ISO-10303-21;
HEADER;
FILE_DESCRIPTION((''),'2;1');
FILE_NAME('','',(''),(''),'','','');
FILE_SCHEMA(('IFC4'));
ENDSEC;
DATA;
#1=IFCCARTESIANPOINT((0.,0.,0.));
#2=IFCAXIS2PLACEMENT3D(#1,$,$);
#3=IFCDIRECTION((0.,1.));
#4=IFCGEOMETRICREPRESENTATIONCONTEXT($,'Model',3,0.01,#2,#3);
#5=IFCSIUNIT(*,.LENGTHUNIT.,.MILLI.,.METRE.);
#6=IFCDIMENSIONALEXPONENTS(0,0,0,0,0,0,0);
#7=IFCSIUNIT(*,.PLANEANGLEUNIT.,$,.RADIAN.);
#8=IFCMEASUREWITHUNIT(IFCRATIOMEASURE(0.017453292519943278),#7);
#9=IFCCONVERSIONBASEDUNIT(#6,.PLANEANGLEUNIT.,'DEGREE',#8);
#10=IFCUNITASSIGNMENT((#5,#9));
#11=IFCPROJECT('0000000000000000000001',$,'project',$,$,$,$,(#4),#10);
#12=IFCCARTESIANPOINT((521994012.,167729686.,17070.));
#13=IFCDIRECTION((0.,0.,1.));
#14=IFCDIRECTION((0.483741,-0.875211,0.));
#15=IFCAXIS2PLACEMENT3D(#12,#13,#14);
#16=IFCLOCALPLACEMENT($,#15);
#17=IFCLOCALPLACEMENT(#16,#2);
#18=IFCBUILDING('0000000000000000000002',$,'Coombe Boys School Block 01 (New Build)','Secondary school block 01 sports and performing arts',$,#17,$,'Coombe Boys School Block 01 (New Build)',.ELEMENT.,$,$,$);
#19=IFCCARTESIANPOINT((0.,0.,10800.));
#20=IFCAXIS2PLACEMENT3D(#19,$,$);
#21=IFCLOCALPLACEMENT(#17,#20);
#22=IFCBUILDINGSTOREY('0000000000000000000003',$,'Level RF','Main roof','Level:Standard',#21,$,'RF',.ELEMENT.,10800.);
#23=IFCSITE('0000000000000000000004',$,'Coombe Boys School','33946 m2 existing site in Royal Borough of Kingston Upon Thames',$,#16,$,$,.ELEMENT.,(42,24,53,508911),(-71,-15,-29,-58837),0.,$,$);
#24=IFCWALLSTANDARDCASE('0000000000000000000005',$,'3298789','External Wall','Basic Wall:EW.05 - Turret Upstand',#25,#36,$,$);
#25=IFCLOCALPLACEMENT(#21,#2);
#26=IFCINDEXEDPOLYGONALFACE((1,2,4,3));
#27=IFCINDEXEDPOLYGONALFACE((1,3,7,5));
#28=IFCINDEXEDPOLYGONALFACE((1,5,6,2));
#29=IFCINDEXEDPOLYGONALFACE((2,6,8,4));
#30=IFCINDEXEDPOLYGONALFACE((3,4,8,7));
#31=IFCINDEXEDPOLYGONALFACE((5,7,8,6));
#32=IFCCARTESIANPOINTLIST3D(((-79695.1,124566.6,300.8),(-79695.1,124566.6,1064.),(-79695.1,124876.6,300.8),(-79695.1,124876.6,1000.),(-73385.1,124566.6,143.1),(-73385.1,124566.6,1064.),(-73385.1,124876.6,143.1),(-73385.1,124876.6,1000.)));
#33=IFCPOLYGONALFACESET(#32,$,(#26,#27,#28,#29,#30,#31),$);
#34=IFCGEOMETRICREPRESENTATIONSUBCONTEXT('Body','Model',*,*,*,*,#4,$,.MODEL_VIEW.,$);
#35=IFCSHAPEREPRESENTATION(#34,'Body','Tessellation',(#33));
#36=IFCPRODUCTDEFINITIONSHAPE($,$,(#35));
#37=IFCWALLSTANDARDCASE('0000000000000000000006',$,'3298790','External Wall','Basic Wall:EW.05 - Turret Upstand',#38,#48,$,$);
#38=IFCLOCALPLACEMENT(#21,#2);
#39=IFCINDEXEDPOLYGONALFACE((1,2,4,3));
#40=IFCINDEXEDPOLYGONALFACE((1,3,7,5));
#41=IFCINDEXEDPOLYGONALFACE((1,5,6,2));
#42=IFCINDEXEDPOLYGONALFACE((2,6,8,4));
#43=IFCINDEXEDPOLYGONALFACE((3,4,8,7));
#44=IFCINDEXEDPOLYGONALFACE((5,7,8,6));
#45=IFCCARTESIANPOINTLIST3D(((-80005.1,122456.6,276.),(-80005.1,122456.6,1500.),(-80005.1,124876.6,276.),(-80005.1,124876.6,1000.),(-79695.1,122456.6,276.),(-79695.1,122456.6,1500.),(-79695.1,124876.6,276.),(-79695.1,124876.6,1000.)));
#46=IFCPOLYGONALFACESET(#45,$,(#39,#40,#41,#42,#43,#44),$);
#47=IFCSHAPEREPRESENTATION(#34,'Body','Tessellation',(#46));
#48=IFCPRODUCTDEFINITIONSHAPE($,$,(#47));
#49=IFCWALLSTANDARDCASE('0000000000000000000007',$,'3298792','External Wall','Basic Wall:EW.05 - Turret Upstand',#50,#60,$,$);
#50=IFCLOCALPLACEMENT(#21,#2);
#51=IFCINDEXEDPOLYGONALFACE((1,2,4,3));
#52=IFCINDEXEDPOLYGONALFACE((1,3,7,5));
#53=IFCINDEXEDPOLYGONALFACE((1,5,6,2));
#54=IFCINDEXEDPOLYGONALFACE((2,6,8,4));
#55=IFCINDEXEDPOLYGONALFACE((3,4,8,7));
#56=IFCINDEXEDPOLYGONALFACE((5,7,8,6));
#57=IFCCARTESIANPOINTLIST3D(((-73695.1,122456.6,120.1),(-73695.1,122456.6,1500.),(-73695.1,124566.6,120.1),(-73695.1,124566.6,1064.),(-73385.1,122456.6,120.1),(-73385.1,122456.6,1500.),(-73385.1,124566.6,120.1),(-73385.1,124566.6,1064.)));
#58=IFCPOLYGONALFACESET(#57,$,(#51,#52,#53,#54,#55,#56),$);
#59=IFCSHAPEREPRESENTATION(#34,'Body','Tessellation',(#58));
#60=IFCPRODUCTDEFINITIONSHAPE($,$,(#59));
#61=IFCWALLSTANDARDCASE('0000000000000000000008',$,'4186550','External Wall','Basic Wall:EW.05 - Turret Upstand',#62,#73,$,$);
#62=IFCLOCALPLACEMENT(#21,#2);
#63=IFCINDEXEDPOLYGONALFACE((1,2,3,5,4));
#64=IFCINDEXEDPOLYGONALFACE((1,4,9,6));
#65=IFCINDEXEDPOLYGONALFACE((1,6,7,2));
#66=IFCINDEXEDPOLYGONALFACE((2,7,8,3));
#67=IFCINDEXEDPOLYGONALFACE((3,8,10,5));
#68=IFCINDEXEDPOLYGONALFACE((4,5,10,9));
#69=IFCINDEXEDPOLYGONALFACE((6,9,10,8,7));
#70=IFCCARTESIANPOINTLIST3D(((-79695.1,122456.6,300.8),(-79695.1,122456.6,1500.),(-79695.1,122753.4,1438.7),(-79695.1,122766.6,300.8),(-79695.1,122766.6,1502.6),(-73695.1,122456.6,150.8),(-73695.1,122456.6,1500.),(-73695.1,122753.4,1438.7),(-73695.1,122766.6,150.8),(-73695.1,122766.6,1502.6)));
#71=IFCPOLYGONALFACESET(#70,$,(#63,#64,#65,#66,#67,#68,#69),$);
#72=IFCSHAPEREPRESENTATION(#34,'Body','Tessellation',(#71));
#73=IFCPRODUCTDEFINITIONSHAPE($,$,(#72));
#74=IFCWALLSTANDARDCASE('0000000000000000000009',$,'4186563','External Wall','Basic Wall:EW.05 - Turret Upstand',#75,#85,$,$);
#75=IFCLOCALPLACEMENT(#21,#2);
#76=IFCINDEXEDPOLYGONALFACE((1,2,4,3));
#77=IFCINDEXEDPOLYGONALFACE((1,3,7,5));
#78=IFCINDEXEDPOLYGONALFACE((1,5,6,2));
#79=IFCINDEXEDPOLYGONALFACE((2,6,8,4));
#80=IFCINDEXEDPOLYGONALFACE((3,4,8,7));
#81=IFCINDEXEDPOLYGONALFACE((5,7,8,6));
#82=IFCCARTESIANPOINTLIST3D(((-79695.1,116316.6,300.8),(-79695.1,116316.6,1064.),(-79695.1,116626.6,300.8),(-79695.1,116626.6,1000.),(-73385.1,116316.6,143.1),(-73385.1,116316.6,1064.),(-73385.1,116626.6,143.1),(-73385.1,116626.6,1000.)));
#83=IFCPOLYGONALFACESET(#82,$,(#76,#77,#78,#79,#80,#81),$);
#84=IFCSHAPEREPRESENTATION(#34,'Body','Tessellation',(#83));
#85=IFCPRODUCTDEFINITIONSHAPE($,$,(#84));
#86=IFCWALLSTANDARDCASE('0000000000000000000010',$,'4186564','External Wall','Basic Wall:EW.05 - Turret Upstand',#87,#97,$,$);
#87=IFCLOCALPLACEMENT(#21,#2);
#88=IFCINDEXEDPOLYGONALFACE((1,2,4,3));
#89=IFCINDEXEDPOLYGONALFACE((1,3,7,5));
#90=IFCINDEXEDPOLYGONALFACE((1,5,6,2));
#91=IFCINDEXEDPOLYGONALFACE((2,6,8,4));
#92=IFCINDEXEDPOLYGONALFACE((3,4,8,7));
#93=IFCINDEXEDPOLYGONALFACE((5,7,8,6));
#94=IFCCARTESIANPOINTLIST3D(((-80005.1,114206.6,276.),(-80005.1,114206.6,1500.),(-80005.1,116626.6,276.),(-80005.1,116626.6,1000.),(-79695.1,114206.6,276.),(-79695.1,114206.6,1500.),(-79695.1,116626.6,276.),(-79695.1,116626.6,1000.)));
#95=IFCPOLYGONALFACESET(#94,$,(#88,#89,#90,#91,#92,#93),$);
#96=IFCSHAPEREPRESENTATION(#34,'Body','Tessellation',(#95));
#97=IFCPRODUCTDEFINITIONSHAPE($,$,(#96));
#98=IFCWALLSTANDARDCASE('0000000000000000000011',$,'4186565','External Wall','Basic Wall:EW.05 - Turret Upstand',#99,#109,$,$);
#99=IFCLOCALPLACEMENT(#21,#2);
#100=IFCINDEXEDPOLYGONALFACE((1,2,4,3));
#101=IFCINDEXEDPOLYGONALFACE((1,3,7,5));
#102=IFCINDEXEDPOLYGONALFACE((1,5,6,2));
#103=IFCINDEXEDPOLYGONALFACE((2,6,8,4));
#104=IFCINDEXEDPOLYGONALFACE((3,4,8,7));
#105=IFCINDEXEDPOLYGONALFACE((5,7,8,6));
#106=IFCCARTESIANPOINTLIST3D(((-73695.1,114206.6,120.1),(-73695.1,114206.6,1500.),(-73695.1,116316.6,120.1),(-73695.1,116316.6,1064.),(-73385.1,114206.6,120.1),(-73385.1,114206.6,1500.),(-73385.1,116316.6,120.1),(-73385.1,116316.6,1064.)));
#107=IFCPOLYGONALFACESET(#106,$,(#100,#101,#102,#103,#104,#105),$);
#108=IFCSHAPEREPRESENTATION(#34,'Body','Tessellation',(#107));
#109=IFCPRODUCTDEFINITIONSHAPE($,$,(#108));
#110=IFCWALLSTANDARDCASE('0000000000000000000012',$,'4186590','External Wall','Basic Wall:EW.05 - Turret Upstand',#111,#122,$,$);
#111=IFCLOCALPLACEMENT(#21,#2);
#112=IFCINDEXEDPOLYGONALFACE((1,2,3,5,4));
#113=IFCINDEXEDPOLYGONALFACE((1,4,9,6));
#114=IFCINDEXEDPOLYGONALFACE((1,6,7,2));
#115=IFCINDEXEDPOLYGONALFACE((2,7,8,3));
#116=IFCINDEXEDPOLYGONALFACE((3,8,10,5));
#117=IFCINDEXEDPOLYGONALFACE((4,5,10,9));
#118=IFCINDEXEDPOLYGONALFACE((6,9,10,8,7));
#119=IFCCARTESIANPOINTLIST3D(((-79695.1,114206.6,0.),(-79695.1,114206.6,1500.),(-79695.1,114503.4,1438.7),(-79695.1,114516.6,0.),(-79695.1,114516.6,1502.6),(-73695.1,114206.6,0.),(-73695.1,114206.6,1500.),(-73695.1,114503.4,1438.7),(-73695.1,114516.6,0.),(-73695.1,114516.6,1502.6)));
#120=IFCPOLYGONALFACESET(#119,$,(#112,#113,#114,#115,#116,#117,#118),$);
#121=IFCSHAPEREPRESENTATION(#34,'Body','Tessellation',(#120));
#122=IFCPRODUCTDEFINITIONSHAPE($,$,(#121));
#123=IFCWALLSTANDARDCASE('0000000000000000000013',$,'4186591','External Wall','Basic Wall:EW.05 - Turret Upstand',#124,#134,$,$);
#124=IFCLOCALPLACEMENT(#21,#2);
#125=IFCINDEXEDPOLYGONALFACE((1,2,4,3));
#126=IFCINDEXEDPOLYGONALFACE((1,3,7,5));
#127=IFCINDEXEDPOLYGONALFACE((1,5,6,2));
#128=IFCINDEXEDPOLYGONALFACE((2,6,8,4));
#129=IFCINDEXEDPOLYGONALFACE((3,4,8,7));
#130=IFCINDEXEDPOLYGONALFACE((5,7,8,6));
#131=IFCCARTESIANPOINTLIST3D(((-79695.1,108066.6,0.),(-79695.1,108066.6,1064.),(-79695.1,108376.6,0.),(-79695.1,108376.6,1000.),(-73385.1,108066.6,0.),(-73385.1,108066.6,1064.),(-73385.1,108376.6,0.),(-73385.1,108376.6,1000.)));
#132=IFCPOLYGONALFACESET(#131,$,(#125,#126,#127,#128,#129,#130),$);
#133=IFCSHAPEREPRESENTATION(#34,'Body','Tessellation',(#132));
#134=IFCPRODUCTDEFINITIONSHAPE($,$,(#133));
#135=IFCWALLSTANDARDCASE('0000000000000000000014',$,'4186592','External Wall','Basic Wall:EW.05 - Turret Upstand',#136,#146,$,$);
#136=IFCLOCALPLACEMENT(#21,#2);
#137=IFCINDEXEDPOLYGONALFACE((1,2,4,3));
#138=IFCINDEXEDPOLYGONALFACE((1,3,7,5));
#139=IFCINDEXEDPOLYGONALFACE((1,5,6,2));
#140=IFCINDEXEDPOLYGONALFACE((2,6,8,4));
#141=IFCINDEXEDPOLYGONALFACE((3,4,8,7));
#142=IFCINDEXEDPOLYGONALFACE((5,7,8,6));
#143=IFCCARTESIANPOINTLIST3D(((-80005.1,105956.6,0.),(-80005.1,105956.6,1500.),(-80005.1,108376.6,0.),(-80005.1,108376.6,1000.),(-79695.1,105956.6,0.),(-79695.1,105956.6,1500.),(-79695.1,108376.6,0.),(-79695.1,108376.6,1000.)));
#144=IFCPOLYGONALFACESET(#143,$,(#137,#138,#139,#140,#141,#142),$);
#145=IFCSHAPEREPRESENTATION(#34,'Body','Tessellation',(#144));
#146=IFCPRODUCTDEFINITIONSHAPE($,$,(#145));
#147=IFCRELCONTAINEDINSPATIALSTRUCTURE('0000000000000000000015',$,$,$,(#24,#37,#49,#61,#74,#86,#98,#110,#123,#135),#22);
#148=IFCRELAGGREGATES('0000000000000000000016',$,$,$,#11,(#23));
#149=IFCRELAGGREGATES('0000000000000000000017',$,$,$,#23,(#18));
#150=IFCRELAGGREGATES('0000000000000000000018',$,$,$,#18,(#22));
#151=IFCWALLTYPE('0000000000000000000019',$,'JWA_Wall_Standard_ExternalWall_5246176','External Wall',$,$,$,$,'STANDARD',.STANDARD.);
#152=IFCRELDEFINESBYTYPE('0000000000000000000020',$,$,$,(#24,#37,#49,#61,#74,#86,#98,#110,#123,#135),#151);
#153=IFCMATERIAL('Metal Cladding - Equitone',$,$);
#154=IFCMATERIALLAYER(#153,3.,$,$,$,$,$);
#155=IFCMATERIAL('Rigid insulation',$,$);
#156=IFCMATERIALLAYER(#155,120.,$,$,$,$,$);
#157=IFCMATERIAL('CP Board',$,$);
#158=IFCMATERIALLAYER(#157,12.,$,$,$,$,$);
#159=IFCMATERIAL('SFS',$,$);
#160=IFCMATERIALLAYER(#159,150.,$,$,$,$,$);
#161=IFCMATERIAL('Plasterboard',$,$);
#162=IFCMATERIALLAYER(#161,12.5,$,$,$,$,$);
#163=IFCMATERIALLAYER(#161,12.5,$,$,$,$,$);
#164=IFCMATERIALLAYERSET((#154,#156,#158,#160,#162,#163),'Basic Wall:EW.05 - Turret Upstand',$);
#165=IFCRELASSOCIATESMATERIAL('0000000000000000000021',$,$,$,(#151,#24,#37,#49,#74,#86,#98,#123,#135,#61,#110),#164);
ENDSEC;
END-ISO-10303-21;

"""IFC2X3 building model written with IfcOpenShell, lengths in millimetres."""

from ifc_helpers import new_model, entity, si_unit, converted_unit, direction, frame, frame_2d, origin, place, context, subcontext, project, spatial, polyline, rectangle, extrude, clip, halfspace, bounded_halfspace, material, layer, layer_set, layer_usage, type_object, element, save


model = new_model("IFC2X3")

# Units and contexts
model_context = context("Model", 3, precision=0.01, world=origin(), true_north=direction((0.0, 1.0)))
body_context = subcontext(model_context, "Body", "Model", "MODEL_VIEW")
ifc_project = project(units=[si_unit("LENGTHUNIT", "METRE", prefix="MILLI"), converted_unit("PLANEANGLEUNIT", "DEGREE", entity("IfcRatioMeasure", 0.017453292519943278), si_unit("PLANEANGLEUNIT", "RADIAN"), dimensions=[0, 0, 0, 0, 0, 0, 0])], contexts=[model_context])

# Site, building, storey
site_placement = place(None, frame((521994012.0, 167729686.0, 17070.0), z_axis=(0.0, 0.0, 1.0), x_axis=(0.483741, -0.875211, 0.0)))
site = spatial("IfcSite", under=ifc_project, at=site_placement, Name="Coombe Boys School", Description="33946 m2 existing site in Royal Borough of Kingston Upon Thames", CompositionType="ELEMENT", RefLatitude=(42, 24, 53, 508911), RefLongitude=(-71, -15, -29, -58837), RefElevation=0.0)
building_placement = place(site_placement, origin())
building = spatial("IfcBuilding", under=site, at=building_placement, Name="Coombe Boys School Block 01 (New Build)", Description="Secondary school block 01 sports and performing arts", LongName="Coombe Boys School Block 01 (New Build)", CompositionType="ELEMENT")
storey_placement = place(building_placement, frame((0.0, 0.0, 10800.0)))
storey = spatial("IfcBuildingStorey", under=building, at=storey_placement, Name="Level RF", Description="Main roof", ObjectType="Level:Standard", LongName="RF", CompositionType="ELEMENT", Elevation=10800.0)

# Walls
ifc_material_1 = material(Name="Metal Cladding - Equitone")
ifc_layer_1 = layer(ifc_material_1, 3.0)
ifc_material_2 = material(Name="Rigid insulation")
ifc_layer_2 = layer(ifc_material_2, 120.0)
ifc_material_3 = material(Name="CP Board")
ifc_layer_3 = layer(ifc_material_3, 12.0)
ifc_material_4 = material(Name="SFS")
ifc_layer_4 = layer(ifc_material_4, 150.0)
ifc_material_5 = material(Name="Plasterboard")
ifc_layer_5 = layer(ifc_material_5, 12.5)
ifc_layer_6 = layer(ifc_material_5, 12.5)
ifc_layer_set_1 = layer_set([ifc_layer_1, ifc_layer_2, ifc_layer_3, ifc_layer_4, ifc_layer_5, ifc_layer_6], Name="Basic Wall:EW.05 - Turret Upstand")
ifc_layer_usage_1 = layer_usage(ifc_layer_set_1, "AXIS2", "POSITIVE", -155.0)
wall_type_1 = type_object("IfcWallType", Name="JWA_Wall_Standard_ExternalWall_5246176", Description="External Wall", ElementType="STANDARD", PredefinedType="STANDARD", material=ifc_layer_set_1)
wall_1_placement = place(storey_placement, frame((-73385.1, 124721.6, 143.1), z_axis=(0.0, 0.0, 1.0), x_axis=(-1.0, 0.0, 0.0)))
element("IfcWallStandardCase", 1, at=wall_1_placement, inside=storey, type_object=wall_type_1, material=ifc_layer_usage_1, Name="3298789", Description="External Wall", ObjectType="Basic Wall:EW.05 - Turret Upstand", context=body_context, shape_type="Clipping", body=[
    clip(clip(extrude(rectangle(XDim=6310.0, YDim=310.0, at=frame_2d((3155.0, 0.0), x_axis=(-1.0, 0.0))), origin(), (0.0, 0.0, 1.0), 921.0), bounded_halfspace(frame((0.0, -155.0, 856.9), z_axis=(0.0, -0.202338, 0.979316), x_axis=(1.0, 0.0, 0.0)), False, frame((0.0, -155.0, 856.9)), polyline([(0.0, 0.0), (6310.0, 0.0), (6310.0, 310.0), (310.0, 310.0), (0.0, 310.0), (0.0, 0.0)]))), halfspace(frame((6310.0, -155.0, 157.8), z_axis=(0.024992, 0.0, -0.999688), x_axis=(0.0, 1.0, 0.0)), False)),
])
wall_2_placement = place(storey_placement, frame((-79850.1, 124876.6, 276.0), z_axis=(0.0, 0.0, 1.0), x_axis=(0.0, -1.0, 0.0)))
element("IfcWallStandardCase", 2, at=wall_2_placement, inside=storey, type_object=wall_type_1, material=ifc_layer_usage_1, Name="3298790", Description="External Wall", ObjectType="Basic Wall:EW.05 - Turret Upstand", context=body_context, shape_type="Clipping", body=[
    clip(extrude(rectangle(XDim=2420.0, YDim=310.0, at=frame_2d((1210.0, 0.0), x_axis=(-1.0, 0.0))), origin(), (0.0, 0.0, 1.0), 1224.0), bounded_halfspace(frame((0.0, -155.0, 724.0), z_axis=(-0.202338, 0.0, 0.979316), x_axis=(0.0, -1.0, 0.0)), False, frame((0.0, -155.0, 724.0)), polyline([(0.0, 0.0), (2420.0, 0.0), (2420.0, 310.0), (2123.2, 310.0), (360.4, 310.0), (310.0, 310.0), (0.0, 310.0), (0.0, 0.0)]))),
])
wall_3_placement = place(storey_placement, frame((-73540.1, 122456.6, 120.1), z_axis=(0.0, 0.0, 1.0), x_axis=(0.0, 1.0, 0.0)))
element("IfcWallStandardCase", 3, at=wall_3_placement, inside=storey, type_object=wall_type_1, material=ifc_layer_usage_1, Name="3298792", Description="External Wall", ObjectType="Basic Wall:EW.05 - Turret Upstand", context=body_context, shape_type="Clipping", body=[
    clip(extrude(rectangle(XDim=2110.0, YDim=310.0, at=frame_2d((1055.0, 0.0), x_axis=(-1.0, 0.0))), origin(), (0.0, 0.0, 1.0), 1379.9), bounded_halfspace(frame((0.0, -155.0, 1379.9), z_axis=(0.202338, 0.0, 0.979316), x_axis=(0.0, 1.0, 0.0)), False, frame((0.0, -155.0, 1379.9)), polyline([(0.0, 0.0), (2110.0, 0.0), (2110.0, 310.0), (2059.6, 310.0), (296.8, 310.0), (0.0, 310.0), (0.0, 0.0)]))),
])
ifc_layer_usage_2 = layer_usage(ifc_layer_set_1, "AXIS2", "NEGATIVE", 155.0)
wall_4_placement = place(storey_placement, frame((-73695.1, 122611.6, 150.8), z_axis=(0.0, 0.0, 1.0), x_axis=(-1.0, 0.0, 0.0)))
element("IfcWallStandardCase", 4, at=wall_4_placement, inside=storey, type_object=wall_type_1, material=ifc_layer_usage_2, Name="4186550", Description="External Wall", ObjectType="Basic Wall:EW.05 - Turret Upstand", context=body_context, shape_type="Clipping", body=[
    clip(clip(clip(extrude(rectangle(XDim=6000.0, YDim=310.0, at=frame_2d((3000.0, 0.0), x_axis=(-1.0, 0.0))), origin(), (0.0, 0.0, 1.0), 1351.8), bounded_halfspace(frame((0.0, -155.0, 1351.8), z_axis=(0.0, 0.979316, 0.202338), x_axis=(0.0, -0.202338, 0.979316)), False, frame((0.0, -155.0, 1351.8)), polyline([(0.0, 0.0), (6000.0, 0.0), (6000.0, 13.2), (0.0, 13.2), (0.0, 0.0)]))), bounded_halfspace(frame((6000.0, -141.8, 1287.9), z_axis=(0.0, -0.202338, 0.979316), x_axis=(1.0, 0.0, 0.0)), False, frame((6000.0, -141.8, 1287.9)), polyline([(0.0, 0.0), (0.0, 296.8), (-6000.0, 296.8), (-6000.0, 0.0), (0.0, 0.0)]))), halfspace(frame((6000.0, -155.0, 150.0), z_axis=(0.024992, 0.0, -0.999688), x_axis=(0.0, 1.0, 0.0)), False)),
])
wall_5_placement = place(storey_placement, frame((-73385.1, 116471.6, 143.1), z_axis=(0.0, 0.0, 1.0), x_axis=(-1.0, 0.0, 0.0)))
element("IfcWallStandardCase", 5, at=wall_5_placement, inside=storey, type_object=wall_type_1, material=ifc_layer_usage_1, Name="4186563", Description="External Wall", ObjectType="Basic Wall:EW.05 - Turret Upstand", context=body_context, shape_type="Clipping", body=[
    clip(clip(extrude(rectangle(XDim=6310.0, YDim=310.0, at=frame_2d((3155.0, 0.0), x_axis=(-1.0, 0.0))), origin(), (0.0, 0.0, 1.0), 921.0), bounded_halfspace(frame((0.0, -155.0, 856.9), z_axis=(0.0, -0.202338, 0.979316), x_axis=(1.0, 0.0, 0.0)), False, frame((0.0, -155.0, 856.9)), polyline([(0.0, 0.0), (6310.0, 0.0), (6310.0, 310.0), (310.0, 310.0), (0.0, 310.0), (0.0, 0.0)]))), halfspace(frame((6310.0, -155.0, 157.8), z_axis=(0.024992, 0.0, -0.999688), x_axis=(0.0, 1.0, 0.0)), False)),
])
wall_6_placement = place(storey_placement, frame((-79850.1, 116626.6, 276.0), z_axis=(0.0, 0.0, 1.0), x_axis=(0.0, -1.0, 0.0)))
element("IfcWallStandardCase", 6, at=wall_6_placement, inside=storey, type_object=wall_type_1, material=ifc_layer_usage_1, Name="4186564", Description="External Wall", ObjectType="Basic Wall:EW.05 - Turret Upstand", context=body_context, shape_type="Clipping", body=[
    clip(extrude(rectangle(XDim=2420.0, YDim=310.0, at=frame_2d((1210.0, 0.0), x_axis=(-1.0, 0.0))), origin(), (0.0, 0.0, 1.0), 1224.0), bounded_halfspace(frame((0.0, -155.0, 724.0), z_axis=(-0.202338, 0.0, 0.979316), x_axis=(0.0, -1.0, 0.0)), False, frame((0.0, -155.0, 724.0)), polyline([(0.0, 0.0), (2420.0, 0.0), (2420.0, 310.0), (2123.2, 310.0), (360.4, 310.0), (310.0, 310.0), (0.0, 310.0), (0.0, 0.0)]))),
])
wall_7_placement = place(storey_placement, frame((-73540.1, 114206.6, 120.1), z_axis=(0.0, 0.0, 1.0), x_axis=(0.0, 1.0, 0.0)))
element("IfcWallStandardCase", 7, at=wall_7_placement, inside=storey, type_object=wall_type_1, material=ifc_layer_usage_1, Name="4186565", Description="External Wall", ObjectType="Basic Wall:EW.05 - Turret Upstand", context=body_context, shape_type="Clipping", body=[
    clip(extrude(rectangle(XDim=2110.0, YDim=310.0, at=frame_2d((1055.0, 0.0), x_axis=(-1.0, 0.0))), origin(), (0.0, 0.0, 1.0), 1379.9), bounded_halfspace(frame((0.0, -155.0, 1379.9), z_axis=(0.202338, 0.0, 0.979316), x_axis=(0.0, 1.0, 0.0)), False, frame((0.0, -155.0, 1379.9)), polyline([(0.0, 0.0), (2110.0, 0.0), (2110.0, 310.0), (2059.6, 310.0), (296.8, 310.0), (0.0, 310.0), (0.0, 0.0)]))),
])
wall_8_placement = place(storey_placement, frame((-73695.1, 114361.6, 0.0), z_axis=(0.0, 0.0, 1.0), x_axis=(-1.0, 0.0, 0.0)))
element("IfcWallStandardCase", 8, at=wall_8_placement, inside=storey, type_object=wall_type_1, material=ifc_layer_usage_2, Name="4186590", Description="External Wall", ObjectType="Basic Wall:EW.05 - Turret Upstand", context=body_context, shape_type="Clipping", body=[
    clip(clip(extrude(rectangle(XDim=6000.0, YDim=310.0, at=frame_2d((3000.0, 0.0), x_axis=(-1.0, 0.0))), origin(), (0.0, 0.0, 1.0), 1502.6), bounded_halfspace(frame((0.0, -155.0, 1502.6), z_axis=(0.0, 0.979316, 0.202338), x_axis=(0.0, -0.202338, 0.979316)), False, frame((0.0, -155.0, 1502.6)), polyline([(0.0, 0.0), (6000.0, 0.0), (6000.0, 13.2), (0.0, 13.2), (0.0, 0.0)]))), bounded_halfspace(frame((6000.0, -141.8, 1438.7), z_axis=(0.0, -0.202338, 0.979316), x_axis=(1.0, 0.0, 0.0)), False, frame((6000.0, -141.8, 1438.7)), polyline([(0.0, 0.0), (0.0, 296.8), (-6000.0, 296.8), (-6000.0, 0.0), (0.0, 0.0)]))),
])
wall_9_placement = place(storey_placement, frame((-73385.1, 108221.6, 0.0), z_axis=(0.0, 0.0, 1.0), x_axis=(-1.0, 0.0, 0.0)))
element("IfcWallStandardCase", 9, at=wall_9_placement, inside=storey, type_object=wall_type_1, material=ifc_layer_usage_1, Name="4186591", Description="External Wall", ObjectType="Basic Wall:EW.05 - Turret Upstand", context=body_context, shape_type="Clipping", body=[
    clip(extrude(rectangle(XDim=6310.0, YDim=310.0, at=frame_2d((3155.0, 0.0), x_axis=(-1.0, 0.0))), origin(), (0.0, 0.0, 1.0), 1064.0), bounded_halfspace(frame((0.0, -155.0, 1000.0), z_axis=(0.0, -0.202338, 0.979316), x_axis=(1.0, 0.0, 0.0)), False, frame((0.0, -155.0, 1000.0)), polyline([(0.0, 0.0), (6310.0, 0.0), (6310.0, 310.0), (310.0, 310.0), (0.0, 310.0), (0.0, 0.0)]))),
])
wall_10_placement = place(storey_placement, frame((-79850.1, 108376.6, 0.0), z_axis=(0.0, 0.0, 1.0), x_axis=(0.0, -1.0, 0.0)))
element("IfcWallStandardCase", 10, at=wall_10_placement, inside=storey, type_object=wall_type_1, material=ifc_layer_usage_1, Name="4186592", Description="External Wall", ObjectType="Basic Wall:EW.05 - Turret Upstand", context=body_context, shape_type="Clipping", body=[
    clip(extrude(rectangle(XDim=2420.0, YDim=310.0, at=frame_2d((1210.0, 0.0), x_axis=(-1.0, 0.0))), origin(), (0.0, 0.0, 1.0), 1500.0), bounded_halfspace(frame((0.0, -155.0, 1000.0), z_axis=(-0.202338, 0.0, 0.979316), x_axis=(0.0, -1.0, 0.0)), False, frame((0.0, -155.0, 1000.0)), polyline([(0.0, 0.0), (2420.0, 0.0), (2420.0, 310.0), (2123.2, 310.0), (360.4, 310.0), (310.0, 310.0), (0.0, 310.0), (0.0, 0.0)]))),
])

save(model, "model.ifc")
